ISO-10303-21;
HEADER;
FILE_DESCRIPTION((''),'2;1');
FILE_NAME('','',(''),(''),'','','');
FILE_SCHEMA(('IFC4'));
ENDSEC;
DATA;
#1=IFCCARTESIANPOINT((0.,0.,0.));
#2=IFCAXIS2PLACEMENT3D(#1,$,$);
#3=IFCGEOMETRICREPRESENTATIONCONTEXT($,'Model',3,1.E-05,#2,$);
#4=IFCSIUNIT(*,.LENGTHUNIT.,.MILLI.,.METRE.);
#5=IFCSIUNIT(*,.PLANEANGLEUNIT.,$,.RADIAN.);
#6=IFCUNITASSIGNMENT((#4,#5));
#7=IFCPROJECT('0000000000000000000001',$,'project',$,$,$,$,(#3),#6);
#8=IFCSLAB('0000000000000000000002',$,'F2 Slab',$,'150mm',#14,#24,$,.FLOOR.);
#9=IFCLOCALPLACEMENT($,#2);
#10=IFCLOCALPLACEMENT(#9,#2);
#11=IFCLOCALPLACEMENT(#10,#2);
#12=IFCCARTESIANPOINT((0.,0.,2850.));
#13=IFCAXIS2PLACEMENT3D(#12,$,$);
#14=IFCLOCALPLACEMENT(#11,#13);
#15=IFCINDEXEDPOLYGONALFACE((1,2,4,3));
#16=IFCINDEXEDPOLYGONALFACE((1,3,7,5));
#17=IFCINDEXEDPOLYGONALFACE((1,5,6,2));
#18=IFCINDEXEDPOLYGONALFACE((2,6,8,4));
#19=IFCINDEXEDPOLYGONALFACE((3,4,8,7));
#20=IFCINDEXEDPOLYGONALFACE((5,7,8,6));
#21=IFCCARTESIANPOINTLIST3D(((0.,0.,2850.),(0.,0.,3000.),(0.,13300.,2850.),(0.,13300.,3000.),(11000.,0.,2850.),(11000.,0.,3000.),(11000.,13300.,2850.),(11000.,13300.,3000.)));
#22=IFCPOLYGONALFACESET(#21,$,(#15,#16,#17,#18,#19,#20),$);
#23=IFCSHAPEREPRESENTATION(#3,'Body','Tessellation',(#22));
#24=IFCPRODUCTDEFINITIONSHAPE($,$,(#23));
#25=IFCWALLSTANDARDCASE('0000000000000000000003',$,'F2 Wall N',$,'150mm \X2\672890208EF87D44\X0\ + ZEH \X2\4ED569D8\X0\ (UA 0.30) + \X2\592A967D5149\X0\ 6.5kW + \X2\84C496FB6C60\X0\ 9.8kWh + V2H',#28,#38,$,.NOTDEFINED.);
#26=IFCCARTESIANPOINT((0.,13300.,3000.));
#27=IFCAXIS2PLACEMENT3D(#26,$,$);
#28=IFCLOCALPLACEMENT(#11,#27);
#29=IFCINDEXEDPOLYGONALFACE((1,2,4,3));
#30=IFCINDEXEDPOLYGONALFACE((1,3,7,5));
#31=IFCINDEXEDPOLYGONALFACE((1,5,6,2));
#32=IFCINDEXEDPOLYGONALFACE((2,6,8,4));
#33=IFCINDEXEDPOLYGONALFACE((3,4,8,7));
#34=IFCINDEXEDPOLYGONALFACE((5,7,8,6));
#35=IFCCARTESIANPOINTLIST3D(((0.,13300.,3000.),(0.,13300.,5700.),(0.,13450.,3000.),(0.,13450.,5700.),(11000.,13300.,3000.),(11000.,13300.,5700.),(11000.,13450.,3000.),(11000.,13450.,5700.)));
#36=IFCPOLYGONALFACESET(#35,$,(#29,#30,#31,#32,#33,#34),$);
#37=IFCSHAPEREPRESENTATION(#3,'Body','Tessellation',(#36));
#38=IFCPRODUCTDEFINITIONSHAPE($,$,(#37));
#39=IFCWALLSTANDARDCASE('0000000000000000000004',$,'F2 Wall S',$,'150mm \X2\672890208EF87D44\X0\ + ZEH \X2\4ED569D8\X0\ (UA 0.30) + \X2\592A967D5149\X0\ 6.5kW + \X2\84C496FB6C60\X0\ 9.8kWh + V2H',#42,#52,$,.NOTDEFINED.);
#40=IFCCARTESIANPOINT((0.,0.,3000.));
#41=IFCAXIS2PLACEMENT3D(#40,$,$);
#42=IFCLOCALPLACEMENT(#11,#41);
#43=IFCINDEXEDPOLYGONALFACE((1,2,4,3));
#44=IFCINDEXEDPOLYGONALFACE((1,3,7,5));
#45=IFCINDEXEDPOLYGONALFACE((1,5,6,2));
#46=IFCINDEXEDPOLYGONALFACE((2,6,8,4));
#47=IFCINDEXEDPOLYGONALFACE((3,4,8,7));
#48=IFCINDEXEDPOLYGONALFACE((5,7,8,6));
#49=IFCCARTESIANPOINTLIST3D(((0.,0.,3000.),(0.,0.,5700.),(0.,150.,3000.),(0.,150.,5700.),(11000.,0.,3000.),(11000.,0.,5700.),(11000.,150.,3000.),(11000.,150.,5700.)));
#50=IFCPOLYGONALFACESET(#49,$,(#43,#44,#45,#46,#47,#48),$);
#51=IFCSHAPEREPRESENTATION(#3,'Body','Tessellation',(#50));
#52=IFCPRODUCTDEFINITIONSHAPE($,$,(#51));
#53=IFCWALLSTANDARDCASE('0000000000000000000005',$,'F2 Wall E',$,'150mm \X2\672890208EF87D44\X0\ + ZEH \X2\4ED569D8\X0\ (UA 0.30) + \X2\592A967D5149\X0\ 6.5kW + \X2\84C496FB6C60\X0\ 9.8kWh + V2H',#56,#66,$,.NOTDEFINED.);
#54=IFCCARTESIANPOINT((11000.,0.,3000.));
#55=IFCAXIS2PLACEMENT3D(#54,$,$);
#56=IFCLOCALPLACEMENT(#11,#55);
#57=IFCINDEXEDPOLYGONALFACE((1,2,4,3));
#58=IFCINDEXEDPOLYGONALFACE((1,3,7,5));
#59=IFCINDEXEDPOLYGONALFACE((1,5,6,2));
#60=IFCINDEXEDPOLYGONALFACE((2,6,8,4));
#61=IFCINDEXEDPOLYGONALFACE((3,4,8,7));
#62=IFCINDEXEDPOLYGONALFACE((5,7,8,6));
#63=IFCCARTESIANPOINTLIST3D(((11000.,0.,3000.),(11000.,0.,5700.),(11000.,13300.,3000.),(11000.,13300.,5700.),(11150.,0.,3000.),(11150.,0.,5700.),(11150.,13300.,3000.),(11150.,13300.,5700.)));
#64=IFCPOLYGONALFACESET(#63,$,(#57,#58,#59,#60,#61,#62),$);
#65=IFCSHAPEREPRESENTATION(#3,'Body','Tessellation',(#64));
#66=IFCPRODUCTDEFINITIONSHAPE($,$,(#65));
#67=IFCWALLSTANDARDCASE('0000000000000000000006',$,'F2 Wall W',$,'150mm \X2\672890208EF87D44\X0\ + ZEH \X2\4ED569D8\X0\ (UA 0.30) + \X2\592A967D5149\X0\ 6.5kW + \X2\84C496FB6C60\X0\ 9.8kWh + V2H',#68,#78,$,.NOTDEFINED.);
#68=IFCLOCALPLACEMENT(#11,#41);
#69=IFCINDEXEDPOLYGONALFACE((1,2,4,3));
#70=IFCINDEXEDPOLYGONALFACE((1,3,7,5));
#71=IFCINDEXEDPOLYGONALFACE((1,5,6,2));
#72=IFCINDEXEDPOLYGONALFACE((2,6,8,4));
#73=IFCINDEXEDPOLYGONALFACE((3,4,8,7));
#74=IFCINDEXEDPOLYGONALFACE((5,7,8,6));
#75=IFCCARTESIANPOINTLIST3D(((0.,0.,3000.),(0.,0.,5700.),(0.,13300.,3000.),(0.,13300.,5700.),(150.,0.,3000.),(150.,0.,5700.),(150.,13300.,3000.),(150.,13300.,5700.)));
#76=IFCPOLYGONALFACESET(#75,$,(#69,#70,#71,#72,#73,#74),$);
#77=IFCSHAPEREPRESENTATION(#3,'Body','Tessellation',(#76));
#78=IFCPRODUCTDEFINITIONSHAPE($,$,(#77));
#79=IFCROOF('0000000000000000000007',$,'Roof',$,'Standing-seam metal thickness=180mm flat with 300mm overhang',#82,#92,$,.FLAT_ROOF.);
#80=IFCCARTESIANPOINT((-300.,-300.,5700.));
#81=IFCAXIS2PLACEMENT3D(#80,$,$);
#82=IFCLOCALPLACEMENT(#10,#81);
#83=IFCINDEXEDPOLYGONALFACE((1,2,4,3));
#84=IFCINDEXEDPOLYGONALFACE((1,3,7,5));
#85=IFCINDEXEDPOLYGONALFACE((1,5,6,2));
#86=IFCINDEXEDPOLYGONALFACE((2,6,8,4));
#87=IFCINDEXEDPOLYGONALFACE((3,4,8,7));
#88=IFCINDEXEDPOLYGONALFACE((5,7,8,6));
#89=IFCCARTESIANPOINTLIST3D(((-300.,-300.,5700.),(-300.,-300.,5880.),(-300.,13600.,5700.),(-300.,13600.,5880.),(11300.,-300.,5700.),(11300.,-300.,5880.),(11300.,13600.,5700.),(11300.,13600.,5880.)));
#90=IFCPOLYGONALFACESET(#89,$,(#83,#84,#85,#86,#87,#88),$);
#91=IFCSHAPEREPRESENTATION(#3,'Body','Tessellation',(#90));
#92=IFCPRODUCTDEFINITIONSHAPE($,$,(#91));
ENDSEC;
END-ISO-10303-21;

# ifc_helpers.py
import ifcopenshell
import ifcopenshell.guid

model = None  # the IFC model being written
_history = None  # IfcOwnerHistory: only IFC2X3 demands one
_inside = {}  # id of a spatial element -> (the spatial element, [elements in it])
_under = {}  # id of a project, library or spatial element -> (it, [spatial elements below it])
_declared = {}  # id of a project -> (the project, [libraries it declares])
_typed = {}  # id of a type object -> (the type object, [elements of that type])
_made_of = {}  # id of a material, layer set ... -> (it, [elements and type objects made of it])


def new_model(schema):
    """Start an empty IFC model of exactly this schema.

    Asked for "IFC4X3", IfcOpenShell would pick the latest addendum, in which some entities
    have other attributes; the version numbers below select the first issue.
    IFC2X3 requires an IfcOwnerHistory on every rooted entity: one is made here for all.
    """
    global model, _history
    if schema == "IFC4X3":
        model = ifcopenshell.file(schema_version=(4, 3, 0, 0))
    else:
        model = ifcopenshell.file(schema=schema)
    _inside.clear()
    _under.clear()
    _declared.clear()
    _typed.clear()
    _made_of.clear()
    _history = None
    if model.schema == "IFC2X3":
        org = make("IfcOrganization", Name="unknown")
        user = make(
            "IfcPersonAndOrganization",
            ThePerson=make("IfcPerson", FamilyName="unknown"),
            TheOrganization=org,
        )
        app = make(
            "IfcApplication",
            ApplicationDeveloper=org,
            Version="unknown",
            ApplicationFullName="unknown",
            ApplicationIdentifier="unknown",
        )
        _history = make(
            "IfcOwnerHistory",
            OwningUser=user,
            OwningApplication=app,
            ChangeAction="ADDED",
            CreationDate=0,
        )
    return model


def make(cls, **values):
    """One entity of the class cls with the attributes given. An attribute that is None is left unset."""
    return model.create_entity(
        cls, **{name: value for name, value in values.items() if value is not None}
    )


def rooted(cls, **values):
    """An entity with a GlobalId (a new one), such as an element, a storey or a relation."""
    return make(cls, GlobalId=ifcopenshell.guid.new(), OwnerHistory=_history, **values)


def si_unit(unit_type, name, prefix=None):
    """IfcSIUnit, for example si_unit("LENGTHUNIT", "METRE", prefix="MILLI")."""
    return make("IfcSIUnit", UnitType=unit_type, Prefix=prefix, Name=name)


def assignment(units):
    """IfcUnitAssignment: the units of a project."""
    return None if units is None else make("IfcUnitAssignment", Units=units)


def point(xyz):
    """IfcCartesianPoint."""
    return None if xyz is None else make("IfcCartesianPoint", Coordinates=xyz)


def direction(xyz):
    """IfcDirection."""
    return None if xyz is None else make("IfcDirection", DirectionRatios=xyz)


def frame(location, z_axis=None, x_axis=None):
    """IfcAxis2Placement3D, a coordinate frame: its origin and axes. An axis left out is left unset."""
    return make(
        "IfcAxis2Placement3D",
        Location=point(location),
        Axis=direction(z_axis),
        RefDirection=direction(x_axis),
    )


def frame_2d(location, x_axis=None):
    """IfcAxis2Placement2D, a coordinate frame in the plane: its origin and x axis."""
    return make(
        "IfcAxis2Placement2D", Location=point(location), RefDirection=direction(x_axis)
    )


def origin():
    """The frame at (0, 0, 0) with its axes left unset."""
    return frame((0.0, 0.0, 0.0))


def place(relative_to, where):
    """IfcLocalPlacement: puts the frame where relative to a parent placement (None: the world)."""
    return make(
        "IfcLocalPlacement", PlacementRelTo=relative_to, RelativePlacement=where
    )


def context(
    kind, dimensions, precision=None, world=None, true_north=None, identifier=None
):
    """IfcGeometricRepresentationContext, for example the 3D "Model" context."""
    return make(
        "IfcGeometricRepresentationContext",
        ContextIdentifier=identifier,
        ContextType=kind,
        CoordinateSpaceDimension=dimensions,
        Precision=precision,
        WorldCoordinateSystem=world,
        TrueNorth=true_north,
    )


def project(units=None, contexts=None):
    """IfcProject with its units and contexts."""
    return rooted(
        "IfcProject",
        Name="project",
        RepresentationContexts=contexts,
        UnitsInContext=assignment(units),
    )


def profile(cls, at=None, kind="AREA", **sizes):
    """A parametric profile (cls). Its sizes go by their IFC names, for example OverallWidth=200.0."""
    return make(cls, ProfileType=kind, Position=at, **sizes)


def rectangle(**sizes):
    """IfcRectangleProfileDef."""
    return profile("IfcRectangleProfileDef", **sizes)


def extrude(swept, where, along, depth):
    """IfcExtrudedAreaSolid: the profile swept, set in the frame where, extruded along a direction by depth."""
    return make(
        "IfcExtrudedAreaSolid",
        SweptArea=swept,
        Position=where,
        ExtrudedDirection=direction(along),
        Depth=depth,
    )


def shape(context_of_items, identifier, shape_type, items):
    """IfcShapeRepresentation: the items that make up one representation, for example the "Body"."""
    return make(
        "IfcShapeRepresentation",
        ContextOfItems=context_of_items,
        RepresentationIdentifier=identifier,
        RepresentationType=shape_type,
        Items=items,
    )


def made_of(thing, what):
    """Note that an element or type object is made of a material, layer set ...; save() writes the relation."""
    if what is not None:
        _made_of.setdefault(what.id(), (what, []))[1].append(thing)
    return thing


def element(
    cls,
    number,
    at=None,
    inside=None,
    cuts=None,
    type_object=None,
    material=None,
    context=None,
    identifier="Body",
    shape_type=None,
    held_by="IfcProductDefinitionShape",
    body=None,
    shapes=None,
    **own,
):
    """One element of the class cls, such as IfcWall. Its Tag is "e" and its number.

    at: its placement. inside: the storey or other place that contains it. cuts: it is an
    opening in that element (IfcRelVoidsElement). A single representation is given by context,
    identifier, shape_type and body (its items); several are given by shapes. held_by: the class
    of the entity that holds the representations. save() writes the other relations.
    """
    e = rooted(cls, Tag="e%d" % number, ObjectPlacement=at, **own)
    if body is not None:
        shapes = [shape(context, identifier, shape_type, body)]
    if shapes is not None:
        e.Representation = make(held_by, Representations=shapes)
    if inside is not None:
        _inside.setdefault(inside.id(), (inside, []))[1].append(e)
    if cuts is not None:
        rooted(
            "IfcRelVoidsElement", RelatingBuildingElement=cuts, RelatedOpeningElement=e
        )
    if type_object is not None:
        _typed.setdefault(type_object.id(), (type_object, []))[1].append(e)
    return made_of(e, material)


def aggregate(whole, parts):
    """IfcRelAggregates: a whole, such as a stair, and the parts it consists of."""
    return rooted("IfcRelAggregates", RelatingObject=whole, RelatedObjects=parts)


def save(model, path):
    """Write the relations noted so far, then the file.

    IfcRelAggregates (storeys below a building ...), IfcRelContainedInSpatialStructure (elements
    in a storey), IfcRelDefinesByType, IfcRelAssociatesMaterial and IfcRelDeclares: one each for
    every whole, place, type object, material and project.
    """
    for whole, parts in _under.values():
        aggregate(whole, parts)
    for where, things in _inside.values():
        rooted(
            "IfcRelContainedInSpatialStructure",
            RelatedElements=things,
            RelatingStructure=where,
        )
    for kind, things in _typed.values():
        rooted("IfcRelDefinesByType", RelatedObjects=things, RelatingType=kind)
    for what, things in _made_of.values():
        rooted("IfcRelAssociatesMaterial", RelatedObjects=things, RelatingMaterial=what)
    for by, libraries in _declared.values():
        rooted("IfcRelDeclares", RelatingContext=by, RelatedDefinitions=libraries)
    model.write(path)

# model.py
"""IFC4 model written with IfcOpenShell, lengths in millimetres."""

from ifc_helpers import new_model, si_unit, frame, frame_2d, origin, place, context, project, rectangle, extrude, element, save


model = new_model("IFC4")

# Units and contexts
model_context = context("Model", 3, precision=1e-05, world=origin())
ifc_project = project(units=[si_unit("LENGTHUNIT", "METRE", prefix="MILLI"), si_unit("PLANEANGLEUNIT", "RADIAN")], contexts=[model_context])

# Slab
placement_1 = place(None, origin())
placement_2 = place(placement_1, origin())
placement_3 = place(placement_2, origin())
slab_placement = place(placement_3, frame((0.0, 0.0, 2850.0)))
element("IfcSlab", 1, at=slab_placement, Name="F2 Slab", ObjectType="150mm", PredefinedType="FLOOR", context=model_context, shape_type="SweptSolid", body=[
    extrude(rectangle(XDim=11000.0, YDim=13300.0, at=frame_2d((5500.0, 6650.0))), frame((0.0, 0.0, 2850.0)), (0.0, 0.0, 1.0), 150.0),
])

# Walls
wall_1_placement = place(placement_3, frame((0.0, 13300.0, 3000.0)))
element("IfcWallStandardCase", 2, at=wall_1_placement, Name="F2 Wall N", ObjectType="150mm 木造軸組 + ZEH 仕様 (UA 0.30) + 太陽光 6.5kW + 蓄電池 9.8kWh + V2H", PredefinedType="NOTDEFINED", context=model_context, shape_type="SweptSolid", body=[
    extrude(rectangle(XDim=11000.0, YDim=150.0, at=frame_2d((5500.0, 75.0))), frame((0.0, 13300.0, 3000.0)), (0.0, 0.0, 1.0), 2700.0),
])
wall_2_placement = place(placement_3, frame((0.0, 0.0, 3000.0)))
element("IfcWallStandardCase", 3, at=wall_2_placement, Name="F2 Wall S", ObjectType="150mm 木造軸組 + ZEH 仕様 (UA 0.30) + 太陽光 6.5kW + 蓄電池 9.8kWh + V2H", PredefinedType="NOTDEFINED", context=model_context, shape_type="SweptSolid", body=[
    extrude(rectangle(XDim=11000.0, YDim=150.0, at=frame_2d((5500.0, 75.0))), frame((0.0, 0.0, 3000.0)), (0.0, 0.0, 1.0), 2700.0),
])
wall_3_placement = place(placement_3, frame((11000.0, 0.0, 3000.0)))
element("IfcWallStandardCase", 4, at=wall_3_placement, Name="F2 Wall E", ObjectType="150mm 木造軸組 + ZEH 仕様 (UA 0.30) + 太陽光 6.5kW + 蓄電池 9.8kWh + V2H", PredefinedType="NOTDEFINED", context=model_context, shape_type="SweptSolid", body=[
    extrude(rectangle(XDim=150.0, YDim=13300.0, at=frame_2d((75.0, 6650.0))), frame((11000.0, 0.0, 3000.0)), (0.0, 0.0, 1.0), 2700.0),
])
wall_4_placement = place(placement_3, frame((0.0, 0.0, 3000.0)))
element("IfcWallStandardCase", 5, at=wall_4_placement, Name="F2 Wall W", ObjectType="150mm 木造軸組 + ZEH 仕様 (UA 0.30) + 太陽光 6.5kW + 蓄電池 9.8kWh + V2H", PredefinedType="NOTDEFINED", context=model_context, shape_type="SweptSolid", body=[
    extrude(rectangle(XDim=150.0, YDim=13300.0, at=frame_2d((75.0, 6650.0))), frame((0.0, 0.0, 3000.0)), (0.0, 0.0, 1.0), 2700.0),
])

# Roof
roof_placement = place(placement_2, frame((-300.0, -300.0, 5700.0)))
element("IfcRoof", 6, at=roof_placement, Name="Roof", ObjectType="Standing-seam metal thickness=180mm flat with 300mm overhang", PredefinedType="FLAT_ROOF", context=model_context, shape_type="SweptSolid", body=[
    extrude(rectangle(XDim=11600.0, YDim=13900.0, at=frame_2d((5800.0, 6950.0))), frame((-300.0, -300.0, 5700.0)), (0.0, 0.0, 1.0), 180.0),
])

save(model, "model.ifc")
